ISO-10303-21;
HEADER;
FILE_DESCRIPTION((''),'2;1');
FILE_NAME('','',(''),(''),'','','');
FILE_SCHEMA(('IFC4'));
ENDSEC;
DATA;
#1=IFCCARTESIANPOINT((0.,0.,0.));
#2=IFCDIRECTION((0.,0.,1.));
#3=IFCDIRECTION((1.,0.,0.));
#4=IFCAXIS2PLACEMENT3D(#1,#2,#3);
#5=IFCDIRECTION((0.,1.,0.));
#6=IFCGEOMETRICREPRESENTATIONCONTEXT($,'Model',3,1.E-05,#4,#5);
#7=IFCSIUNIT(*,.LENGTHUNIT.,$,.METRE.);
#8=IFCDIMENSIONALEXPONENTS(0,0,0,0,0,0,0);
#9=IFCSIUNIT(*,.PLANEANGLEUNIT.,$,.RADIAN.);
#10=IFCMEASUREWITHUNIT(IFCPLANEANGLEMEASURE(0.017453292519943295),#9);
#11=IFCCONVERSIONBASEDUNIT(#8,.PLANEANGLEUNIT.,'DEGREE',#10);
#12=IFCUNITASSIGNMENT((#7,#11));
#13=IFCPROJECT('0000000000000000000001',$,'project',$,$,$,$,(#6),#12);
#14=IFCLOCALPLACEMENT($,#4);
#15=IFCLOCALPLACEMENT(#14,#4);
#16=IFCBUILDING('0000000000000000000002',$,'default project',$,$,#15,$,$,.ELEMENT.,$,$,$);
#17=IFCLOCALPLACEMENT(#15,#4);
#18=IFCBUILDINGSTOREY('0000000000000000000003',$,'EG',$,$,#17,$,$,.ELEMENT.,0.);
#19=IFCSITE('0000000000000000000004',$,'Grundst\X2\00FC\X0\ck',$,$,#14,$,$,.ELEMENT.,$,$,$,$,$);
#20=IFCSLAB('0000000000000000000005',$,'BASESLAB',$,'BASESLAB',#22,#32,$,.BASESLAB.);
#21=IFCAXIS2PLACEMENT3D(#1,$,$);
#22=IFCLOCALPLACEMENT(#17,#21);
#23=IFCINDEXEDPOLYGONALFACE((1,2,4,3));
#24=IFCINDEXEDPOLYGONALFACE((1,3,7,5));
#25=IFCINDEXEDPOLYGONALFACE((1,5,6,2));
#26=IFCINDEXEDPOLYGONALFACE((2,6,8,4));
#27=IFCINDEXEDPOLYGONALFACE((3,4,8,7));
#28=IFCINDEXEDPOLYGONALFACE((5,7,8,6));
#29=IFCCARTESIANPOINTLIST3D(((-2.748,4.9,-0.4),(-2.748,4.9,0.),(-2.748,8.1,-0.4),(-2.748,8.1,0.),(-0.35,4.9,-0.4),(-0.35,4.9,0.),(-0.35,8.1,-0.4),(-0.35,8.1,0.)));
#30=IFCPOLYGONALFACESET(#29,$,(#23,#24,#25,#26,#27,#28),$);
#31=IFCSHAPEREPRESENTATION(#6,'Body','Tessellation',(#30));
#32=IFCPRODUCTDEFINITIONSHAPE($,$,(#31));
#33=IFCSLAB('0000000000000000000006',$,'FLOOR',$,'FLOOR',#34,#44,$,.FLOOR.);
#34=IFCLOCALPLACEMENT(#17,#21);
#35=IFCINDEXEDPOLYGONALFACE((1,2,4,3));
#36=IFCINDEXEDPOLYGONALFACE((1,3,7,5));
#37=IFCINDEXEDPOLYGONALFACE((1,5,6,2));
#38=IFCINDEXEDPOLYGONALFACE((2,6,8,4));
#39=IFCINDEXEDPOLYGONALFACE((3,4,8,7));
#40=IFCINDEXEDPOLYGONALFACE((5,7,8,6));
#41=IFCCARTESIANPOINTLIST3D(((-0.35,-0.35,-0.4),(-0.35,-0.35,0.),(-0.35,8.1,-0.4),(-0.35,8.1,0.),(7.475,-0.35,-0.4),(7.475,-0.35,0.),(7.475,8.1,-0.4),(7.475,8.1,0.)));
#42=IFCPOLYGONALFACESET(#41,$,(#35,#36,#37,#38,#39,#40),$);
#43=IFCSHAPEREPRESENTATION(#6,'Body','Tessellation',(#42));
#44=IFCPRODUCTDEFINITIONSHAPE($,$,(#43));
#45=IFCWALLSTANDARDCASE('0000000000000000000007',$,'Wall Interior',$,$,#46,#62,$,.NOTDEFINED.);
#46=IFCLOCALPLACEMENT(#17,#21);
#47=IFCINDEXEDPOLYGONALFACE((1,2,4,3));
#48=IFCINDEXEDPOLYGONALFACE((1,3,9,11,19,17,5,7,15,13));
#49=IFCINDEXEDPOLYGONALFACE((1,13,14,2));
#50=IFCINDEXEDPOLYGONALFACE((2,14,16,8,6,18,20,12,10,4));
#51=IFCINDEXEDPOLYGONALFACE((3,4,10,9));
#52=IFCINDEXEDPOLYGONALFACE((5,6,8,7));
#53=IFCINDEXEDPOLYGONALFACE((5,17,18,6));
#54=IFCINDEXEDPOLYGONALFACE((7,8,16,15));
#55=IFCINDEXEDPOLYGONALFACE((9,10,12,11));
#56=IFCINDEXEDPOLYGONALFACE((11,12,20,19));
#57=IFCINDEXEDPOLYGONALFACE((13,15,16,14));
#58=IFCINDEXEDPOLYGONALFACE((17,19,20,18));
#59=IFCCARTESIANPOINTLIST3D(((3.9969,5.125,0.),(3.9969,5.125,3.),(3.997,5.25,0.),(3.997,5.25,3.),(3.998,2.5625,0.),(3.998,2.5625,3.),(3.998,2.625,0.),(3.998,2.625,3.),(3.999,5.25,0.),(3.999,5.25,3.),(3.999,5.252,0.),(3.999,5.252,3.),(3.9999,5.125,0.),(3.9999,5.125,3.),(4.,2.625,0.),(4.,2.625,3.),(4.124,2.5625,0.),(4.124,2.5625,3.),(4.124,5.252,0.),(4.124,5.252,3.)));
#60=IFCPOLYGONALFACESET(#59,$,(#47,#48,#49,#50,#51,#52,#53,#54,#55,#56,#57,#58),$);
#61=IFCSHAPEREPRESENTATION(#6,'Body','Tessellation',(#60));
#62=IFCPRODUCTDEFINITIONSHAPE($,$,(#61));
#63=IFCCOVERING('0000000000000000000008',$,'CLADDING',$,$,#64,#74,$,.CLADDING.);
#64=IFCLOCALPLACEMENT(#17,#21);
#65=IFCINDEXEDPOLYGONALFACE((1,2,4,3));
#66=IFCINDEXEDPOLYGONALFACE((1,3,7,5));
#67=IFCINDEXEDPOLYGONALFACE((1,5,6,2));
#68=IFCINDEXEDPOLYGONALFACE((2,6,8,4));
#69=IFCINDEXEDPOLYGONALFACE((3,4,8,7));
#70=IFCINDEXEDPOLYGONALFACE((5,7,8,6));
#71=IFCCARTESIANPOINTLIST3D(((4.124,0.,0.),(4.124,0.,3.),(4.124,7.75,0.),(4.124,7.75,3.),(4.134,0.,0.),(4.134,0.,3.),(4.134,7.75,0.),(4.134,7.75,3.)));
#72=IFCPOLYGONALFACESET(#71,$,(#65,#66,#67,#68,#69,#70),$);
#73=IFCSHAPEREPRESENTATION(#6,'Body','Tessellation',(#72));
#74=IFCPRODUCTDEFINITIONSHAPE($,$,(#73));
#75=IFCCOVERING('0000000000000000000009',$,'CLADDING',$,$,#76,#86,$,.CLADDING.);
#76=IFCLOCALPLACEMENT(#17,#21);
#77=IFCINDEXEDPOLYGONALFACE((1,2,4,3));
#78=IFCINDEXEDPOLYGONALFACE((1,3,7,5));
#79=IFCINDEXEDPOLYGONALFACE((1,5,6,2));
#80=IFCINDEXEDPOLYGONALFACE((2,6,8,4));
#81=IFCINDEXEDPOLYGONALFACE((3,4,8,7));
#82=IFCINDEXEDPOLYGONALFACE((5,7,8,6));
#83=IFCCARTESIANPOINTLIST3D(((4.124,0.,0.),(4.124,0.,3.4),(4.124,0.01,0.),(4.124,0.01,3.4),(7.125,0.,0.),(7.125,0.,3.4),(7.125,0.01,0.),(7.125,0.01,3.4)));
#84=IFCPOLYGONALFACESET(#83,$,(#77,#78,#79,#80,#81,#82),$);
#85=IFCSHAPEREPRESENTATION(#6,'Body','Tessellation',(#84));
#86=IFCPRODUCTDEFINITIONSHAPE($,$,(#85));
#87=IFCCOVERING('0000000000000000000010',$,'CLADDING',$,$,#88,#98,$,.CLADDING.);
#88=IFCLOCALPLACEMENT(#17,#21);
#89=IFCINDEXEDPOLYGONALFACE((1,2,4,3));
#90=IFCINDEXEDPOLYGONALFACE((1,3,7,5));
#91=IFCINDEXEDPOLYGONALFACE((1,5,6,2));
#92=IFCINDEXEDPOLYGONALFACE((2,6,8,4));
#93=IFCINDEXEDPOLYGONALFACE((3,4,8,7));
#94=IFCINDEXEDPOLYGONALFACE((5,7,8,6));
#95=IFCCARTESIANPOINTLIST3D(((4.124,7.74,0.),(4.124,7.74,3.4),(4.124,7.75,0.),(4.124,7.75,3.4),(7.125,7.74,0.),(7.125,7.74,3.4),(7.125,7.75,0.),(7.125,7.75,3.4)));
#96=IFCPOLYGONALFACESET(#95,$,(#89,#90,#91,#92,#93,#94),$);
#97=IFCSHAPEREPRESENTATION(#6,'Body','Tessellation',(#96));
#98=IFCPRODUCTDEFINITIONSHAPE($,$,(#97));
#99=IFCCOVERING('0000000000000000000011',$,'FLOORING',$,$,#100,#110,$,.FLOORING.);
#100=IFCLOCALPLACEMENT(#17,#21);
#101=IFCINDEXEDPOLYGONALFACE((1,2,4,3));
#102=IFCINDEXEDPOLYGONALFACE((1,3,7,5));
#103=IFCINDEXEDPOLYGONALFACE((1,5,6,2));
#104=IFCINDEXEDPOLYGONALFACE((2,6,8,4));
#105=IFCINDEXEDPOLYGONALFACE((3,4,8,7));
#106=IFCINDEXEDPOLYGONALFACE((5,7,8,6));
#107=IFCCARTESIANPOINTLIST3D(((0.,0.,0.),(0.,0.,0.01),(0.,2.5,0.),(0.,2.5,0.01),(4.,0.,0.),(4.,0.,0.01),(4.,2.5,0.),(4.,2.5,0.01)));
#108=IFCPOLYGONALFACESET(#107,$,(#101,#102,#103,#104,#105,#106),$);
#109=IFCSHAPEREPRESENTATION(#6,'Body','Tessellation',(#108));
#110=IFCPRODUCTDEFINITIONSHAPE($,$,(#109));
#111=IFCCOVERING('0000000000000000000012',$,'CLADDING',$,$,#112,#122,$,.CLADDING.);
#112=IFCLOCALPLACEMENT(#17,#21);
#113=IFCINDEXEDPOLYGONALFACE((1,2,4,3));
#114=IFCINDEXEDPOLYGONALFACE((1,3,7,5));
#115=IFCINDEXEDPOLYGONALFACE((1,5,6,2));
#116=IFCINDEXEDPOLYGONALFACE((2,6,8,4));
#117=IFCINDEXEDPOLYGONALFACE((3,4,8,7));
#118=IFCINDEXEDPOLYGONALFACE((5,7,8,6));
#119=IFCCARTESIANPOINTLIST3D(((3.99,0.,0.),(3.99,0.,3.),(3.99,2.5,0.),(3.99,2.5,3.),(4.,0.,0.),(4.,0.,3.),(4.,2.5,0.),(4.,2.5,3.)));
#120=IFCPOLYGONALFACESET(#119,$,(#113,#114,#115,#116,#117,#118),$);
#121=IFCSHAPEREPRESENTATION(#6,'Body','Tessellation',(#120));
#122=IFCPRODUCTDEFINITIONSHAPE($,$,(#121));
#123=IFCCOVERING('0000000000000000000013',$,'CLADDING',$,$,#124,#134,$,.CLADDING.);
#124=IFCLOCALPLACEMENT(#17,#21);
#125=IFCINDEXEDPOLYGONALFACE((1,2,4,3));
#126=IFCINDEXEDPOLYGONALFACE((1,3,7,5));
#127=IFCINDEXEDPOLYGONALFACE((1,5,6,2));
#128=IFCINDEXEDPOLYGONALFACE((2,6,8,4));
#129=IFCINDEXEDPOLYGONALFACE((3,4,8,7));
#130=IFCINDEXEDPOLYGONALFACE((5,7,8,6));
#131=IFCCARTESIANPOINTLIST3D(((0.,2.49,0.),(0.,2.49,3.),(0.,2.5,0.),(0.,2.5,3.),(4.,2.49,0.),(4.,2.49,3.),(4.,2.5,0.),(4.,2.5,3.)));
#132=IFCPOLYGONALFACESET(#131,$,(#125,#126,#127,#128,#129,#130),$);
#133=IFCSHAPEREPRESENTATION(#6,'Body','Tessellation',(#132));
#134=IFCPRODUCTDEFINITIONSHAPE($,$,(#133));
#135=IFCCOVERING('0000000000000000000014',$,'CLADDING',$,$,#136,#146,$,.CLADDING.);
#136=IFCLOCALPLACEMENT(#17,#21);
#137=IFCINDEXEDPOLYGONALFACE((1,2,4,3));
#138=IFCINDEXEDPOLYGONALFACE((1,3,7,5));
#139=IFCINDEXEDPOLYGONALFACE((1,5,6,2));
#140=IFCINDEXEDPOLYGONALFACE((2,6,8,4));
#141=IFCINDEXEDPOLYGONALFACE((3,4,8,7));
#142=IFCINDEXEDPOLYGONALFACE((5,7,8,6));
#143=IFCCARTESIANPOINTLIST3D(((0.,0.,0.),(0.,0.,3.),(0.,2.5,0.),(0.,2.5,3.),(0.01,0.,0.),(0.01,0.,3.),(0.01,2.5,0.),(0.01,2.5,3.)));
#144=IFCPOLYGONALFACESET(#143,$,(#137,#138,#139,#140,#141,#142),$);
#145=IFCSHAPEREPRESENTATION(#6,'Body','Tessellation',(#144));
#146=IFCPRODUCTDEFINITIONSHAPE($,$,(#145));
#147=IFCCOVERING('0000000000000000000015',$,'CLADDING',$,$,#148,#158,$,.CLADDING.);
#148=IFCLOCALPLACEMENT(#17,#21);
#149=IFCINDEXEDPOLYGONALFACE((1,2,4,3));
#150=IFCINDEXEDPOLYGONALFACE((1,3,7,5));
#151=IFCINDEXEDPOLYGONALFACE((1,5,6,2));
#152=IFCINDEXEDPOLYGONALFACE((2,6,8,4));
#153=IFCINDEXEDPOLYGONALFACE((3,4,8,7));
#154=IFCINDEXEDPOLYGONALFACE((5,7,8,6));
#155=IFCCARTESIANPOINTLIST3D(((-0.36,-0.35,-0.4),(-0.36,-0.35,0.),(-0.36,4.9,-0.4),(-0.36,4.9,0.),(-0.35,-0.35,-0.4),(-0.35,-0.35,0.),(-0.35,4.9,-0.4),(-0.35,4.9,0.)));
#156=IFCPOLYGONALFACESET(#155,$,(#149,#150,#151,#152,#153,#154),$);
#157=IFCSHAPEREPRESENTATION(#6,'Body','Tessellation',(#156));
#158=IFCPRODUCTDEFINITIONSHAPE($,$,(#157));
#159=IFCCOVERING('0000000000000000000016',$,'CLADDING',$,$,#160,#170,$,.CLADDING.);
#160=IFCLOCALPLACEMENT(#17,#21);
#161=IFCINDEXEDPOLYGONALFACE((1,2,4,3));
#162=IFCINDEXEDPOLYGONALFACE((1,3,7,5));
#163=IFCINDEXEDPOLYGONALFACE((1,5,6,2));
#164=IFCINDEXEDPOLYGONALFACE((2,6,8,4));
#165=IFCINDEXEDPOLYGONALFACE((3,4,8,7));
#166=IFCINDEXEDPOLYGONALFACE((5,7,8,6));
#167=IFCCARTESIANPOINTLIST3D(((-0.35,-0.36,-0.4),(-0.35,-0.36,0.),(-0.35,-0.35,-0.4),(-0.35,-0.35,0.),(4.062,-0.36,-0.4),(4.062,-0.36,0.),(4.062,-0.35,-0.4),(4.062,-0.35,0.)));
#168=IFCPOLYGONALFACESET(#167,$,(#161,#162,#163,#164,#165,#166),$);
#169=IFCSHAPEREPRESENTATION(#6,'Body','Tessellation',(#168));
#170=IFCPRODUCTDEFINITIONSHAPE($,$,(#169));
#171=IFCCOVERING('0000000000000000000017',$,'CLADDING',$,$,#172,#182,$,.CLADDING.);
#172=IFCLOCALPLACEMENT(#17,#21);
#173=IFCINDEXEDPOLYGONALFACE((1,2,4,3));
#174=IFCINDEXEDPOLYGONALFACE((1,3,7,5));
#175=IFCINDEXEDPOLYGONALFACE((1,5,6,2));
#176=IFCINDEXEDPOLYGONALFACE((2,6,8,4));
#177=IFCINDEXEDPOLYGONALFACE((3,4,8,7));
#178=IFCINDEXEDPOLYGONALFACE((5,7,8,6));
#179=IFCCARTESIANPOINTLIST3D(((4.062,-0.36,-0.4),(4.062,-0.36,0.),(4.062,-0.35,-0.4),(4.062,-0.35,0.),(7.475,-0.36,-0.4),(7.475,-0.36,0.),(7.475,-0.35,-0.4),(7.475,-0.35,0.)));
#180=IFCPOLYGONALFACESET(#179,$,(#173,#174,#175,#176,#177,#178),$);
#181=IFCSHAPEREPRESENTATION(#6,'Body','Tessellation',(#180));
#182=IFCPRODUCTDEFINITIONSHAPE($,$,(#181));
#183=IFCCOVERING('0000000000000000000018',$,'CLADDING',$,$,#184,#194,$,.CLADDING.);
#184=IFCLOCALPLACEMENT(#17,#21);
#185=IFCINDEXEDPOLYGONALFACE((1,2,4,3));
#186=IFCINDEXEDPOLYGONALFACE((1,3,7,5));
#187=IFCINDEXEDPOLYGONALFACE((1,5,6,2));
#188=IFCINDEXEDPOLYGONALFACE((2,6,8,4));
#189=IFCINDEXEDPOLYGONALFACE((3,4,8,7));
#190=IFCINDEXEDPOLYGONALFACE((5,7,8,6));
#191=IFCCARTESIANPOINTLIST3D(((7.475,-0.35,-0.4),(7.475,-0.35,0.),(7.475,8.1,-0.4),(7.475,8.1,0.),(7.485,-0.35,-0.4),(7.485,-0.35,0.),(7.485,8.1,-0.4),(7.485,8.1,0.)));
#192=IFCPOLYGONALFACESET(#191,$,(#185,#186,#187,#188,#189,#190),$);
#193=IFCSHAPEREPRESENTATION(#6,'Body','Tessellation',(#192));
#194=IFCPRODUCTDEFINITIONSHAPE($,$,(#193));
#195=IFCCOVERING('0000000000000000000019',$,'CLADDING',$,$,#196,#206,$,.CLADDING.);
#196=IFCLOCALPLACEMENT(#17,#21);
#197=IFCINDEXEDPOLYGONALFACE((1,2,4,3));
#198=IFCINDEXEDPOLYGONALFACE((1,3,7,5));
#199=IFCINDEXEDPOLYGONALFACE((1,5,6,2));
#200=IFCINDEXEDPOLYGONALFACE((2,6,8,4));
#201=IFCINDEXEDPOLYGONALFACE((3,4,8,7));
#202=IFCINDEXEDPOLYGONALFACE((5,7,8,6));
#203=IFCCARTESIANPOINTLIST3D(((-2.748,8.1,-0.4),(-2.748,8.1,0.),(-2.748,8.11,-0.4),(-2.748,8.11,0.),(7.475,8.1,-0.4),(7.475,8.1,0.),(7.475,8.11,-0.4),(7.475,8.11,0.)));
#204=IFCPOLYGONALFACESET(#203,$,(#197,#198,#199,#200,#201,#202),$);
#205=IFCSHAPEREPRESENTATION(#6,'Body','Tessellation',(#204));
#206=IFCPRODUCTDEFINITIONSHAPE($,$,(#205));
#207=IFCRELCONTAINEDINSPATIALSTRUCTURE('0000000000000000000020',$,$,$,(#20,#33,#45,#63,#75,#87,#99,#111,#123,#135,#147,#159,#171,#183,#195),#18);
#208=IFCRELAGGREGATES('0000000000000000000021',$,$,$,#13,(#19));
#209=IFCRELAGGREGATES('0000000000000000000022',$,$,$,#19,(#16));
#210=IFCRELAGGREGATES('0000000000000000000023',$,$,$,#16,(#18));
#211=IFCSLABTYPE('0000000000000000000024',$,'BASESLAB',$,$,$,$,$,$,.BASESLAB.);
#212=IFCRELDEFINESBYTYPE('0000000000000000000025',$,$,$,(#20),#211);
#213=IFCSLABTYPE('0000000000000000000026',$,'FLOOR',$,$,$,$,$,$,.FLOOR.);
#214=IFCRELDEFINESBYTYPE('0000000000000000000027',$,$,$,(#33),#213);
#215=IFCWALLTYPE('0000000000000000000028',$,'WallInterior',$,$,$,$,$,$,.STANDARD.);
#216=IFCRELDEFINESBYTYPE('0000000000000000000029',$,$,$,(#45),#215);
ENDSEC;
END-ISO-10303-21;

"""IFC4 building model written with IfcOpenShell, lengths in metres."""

from ifc_helpers import new_model, entity, si_unit, converted_unit, direction, frame, origin_with_axes, place, context, project, spatial, polyline, outline, extrude, type_object, element, save


model = new_model("IFC4")

# Units and contexts
model_context = context("Model", 3, precision=1e-05, world=origin_with_axes(), true_north=direction((0.0, 1.0, 0.0)))
ifc_project = project(units=[si_unit("LENGTHUNIT", "METRE"), converted_unit("PLANEANGLEUNIT", "DEGREE", entity("IfcPlaneAngleMeasure", 0.017453292519943295), si_unit("PLANEANGLEUNIT", "RADIAN"), dimensions=[0, 0, 0, 0, 0, 0, 0])], contexts=[model_context])

# Site, building, storey
site_placement = place(None, origin_with_axes())
site = spatial("IfcSite", under=ifc_project, at=site_placement, Name="Grundstück", CompositionType="ELEMENT")
building_placement = place(site_placement, origin_with_axes())
building = spatial("IfcBuilding", under=site, at=building_placement, Name="default project", CompositionType="ELEMENT")
placement_1 = place(building_placement, origin_with_axes())
storey = spatial("IfcBuildingStorey", under=building, at=placement_1, Name="EG", CompositionType="ELEMENT", Elevation=0.0)

# Slabs
slab_type_1 = type_object("IfcSlabType", Name="BASESLAB", PredefinedType="BASESLAB")
slab_1_placement = place(placement_1, frame((0.0, 0.0, -0.4), z_axis=(0.0, 0.0, 1.0), x_axis=(1.0, 0.0, 0.0)))
element("IfcSlab", 1, at=slab_1_placement, inside=storey, type_object=slab_type_1, Name="BASESLAB", ObjectType="BASESLAB", PredefinedType="BASESLAB", context=model_context, shape_type="SweptSolid", body=[
    extrude(outline(polyline([(-0.35, 8.1), (-2.748, 8.1), (-2.748, 4.9), (-0.35, 4.9), (-0.35, 8.1)])), origin_with_axes(), (0.0, 0.0, 1.0), 0.4),
])
slab_type_2 = type_object("IfcSlabType", Name="FLOOR", PredefinedType="FLOOR")
slab_2_placement = place(placement_1, frame((0.0, 0.0, -0.4), z_axis=(0.0, 0.0, 1.0), x_axis=(1.0, 0.0, 0.0)))
element("IfcSlab", 2, at=slab_2_placement, inside=storey, type_object=slab_type_2, Name="FLOOR", ObjectType="FLOOR", PredefinedType="FLOOR", context=model_context, shape_type="SweptSolid", body=[
    extrude(outline(polyline([(7.475, 8.1), (-0.35, 8.1), (-0.35, -0.35), (7.475, -0.35), (7.475, 8.1)])), origin_with_axes(), (0.0, 0.0, 1.0), 0.4),
])

# Wall
wall_type_1 = type_object("IfcWallType", Name="WallInterior", PredefinedType="STANDARD")
wall_1_placement = place(placement_1, frame((4.062, 2.5625, 0.0), z_axis=(0.0, 0.0, 1.0), x_axis=(-0.0001, 1.0, 0.0)))
element("IfcWallStandardCase", 3, at=wall_1_placement, inside=storey, type_object=wall_type_1, Name="Wall Interior", PredefinedType="NOTDEFINED", context=model_context, shape_type="SweptSolid", body=[
    extrude(outline(polyline([(2.6875, 0.0647), (2.5625, 0.0648), (2.5625, 0.0618), (0.0625, 0.062), (0.0625, 0.064), (0.0, 0.064), (0.0, -0.062), (2.6895, -0.0623), (2.6895, 0.0627), (2.6875, 0.0627), (2.6875, 0.0647)])), origin_with_axes(), (0.0, 0.0, 1.0), 3.0),
])

# Coverings
element("IfcCovering", 4, at=placement_1, inside=storey, Name="CLADDING", PredefinedType="CLADDING", context=model_context, shape_type="SweptSolid", body=[
    extrude(outline(polyline([(4.134, 0.0), (4.134, 7.75), (4.124, 7.75), (4.124, 0.0), (4.134, 0.0)])), origin_with_axes(), (0.0, 0.0, 1.0), 3.0),
])
element("IfcCovering", 5, at=placement_1, inside=storey, Name="CLADDING", PredefinedType="CLADDING", context=model_context, shape_type="SweptSolid", body=[
    extrude(outline(polyline([(7.125, 0.01), (4.124, 0.01), (4.124, 0.0), (7.125, 0.0), (7.125, 0.01)])), origin_with_axes(), (0.0, 0.0, 1.0), 3.4),
])
element("IfcCovering", 6, at=placement_1, inside=storey, Name="CLADDING", PredefinedType="CLADDING", context=model_context, shape_type="SweptSolid", body=[
    extrude(outline(polyline([(4.124, 7.74), (7.125, 7.74), (7.125, 7.75), (4.124, 7.75), (4.124, 7.74)])), origin_with_axes(), (0.0, 0.0, 1.0), 3.4),
])
element("IfcCovering", 7, at=placement_1, inside=storey, Name="FLOORING", PredefinedType="FLOORING", context=model_context, shape_type="SweptSolid", body=[
    extrude(outline(polyline([(4.0, 2.5), (0.0, 2.5), (0.0, 0.0), (4.0, 0.0), (4.0, 2.5)])), origin_with_axes(), (0.0, 0.0, 1.0), 0.01),
])
element("IfcCovering", 8, at=placement_1, inside=storey, Name="CLADDING", PredefinedType="CLADDING", context=model_context, shape_type="SweptSolid", body=[
    extrude(outline(polyline([(3.99, 2.5), (3.99, 0.0), (4.0, 0.0), (4.0, 2.5), (3.99, 2.5)])), origin_with_axes(), (0.0, 0.0, 1.0), 3.0),
])
element("IfcCovering", 9, at=placement_1, inside=storey, Name="CLADDING", PredefinedType="CLADDING", context=model_context, shape_type="SweptSolid", body=[
    extrude(outline(polyline([(0.0, 2.49), (4.0, 2.49), (4.0, 2.5), (0.0, 2.5), (0.0, 2.49)])), origin_with_axes(), (0.0, 0.0, 1.0), 3.0),
])
element("IfcCovering", 10, at=placement_1, inside=storey, Name="CLADDING", PredefinedType="CLADDING", context=model_context, shape_type="SweptSolid", body=[
    extrude(outline(polyline([(0.01, 0.0), (0.01, 2.5), (0.0, 2.5), (0.0, 0.0), (0.01, 0.0)])), origin_with_axes(), (0.0, 0.0, 1.0), 3.0),
])
covering_1_placement = place(slab_2_placement, origin_with_axes())
element("IfcCovering", 11, at=covering_1_placement, inside=storey, Name="CLADDING", PredefinedType="CLADDING", context=model_context, shape_type="SweptSolid", body=[
    extrude(outline(polyline([(-0.36, 4.9), (-0.36, -0.35), (-0.35, -0.35), (-0.35, 4.9), (-0.36, 4.9)])), origin_with_axes(), (0.0, 0.0, 1.0), 0.4),
])
covering_2_placement = place(slab_2_placement, origin_with_axes())
element("IfcCovering", 12, at=covering_2_placement, inside=storey, Name="CLADDING", PredefinedType="CLADDING", context=model_context, shape_type="SweptSolid", body=[
    extrude(outline(polyline([(-0.35, -0.36), (4.062, -0.36), (4.062, -0.35), (-0.35, -0.35), (-0.35, -0.36)])), origin_with_axes(), (0.0, 0.0, 1.0), 0.4),
])
covering_3_placement = place(slab_2_placement, origin_with_axes())
element("IfcCovering", 13, at=covering_3_placement, inside=storey, Name="CLADDING", PredefinedType="CLADDING", context=model_context, shape_type="SweptSolid", body=[
    extrude(outline(polyline([(4.062, -0.36), (7.475, -0.36), (7.475, -0.35), (4.062, -0.35), (4.062, -0.36)])), origin_with_axes(), (0.0, 0.0, 1.0), 0.4),
])
covering_4_placement = place(slab_2_placement, origin_with_axes())
element("IfcCovering", 14, at=covering_4_placement, inside=storey, Name="CLADDING", PredefinedType="CLADDING", context=model_context, shape_type="SweptSolid", body=[
    extrude(outline(polyline([(7.485, -0.35), (7.485, 8.1), (7.475, 8.1), (7.475, -0.35), (7.485, -0.35)])), origin_with_axes(), (0.0, 0.0, 1.0), 0.4),
])
covering_5_placement = place(slab_2_placement, origin_with_axes())
element("IfcCovering", 15, at=covering_5_placement, inside=storey, Name="CLADDING", PredefinedType="CLADDING", context=model_context, shape_type="SweptSolid", body=[
    extrude(outline(polyline([(7.475, 8.11), (-2.748, 8.11), (-2.748, 8.1), (7.475, 8.1), (7.475, 8.11)])), origin_with_axes(), (0.0, 0.0, 1.0), 0.4),
])

save(model, "model.ifc")
